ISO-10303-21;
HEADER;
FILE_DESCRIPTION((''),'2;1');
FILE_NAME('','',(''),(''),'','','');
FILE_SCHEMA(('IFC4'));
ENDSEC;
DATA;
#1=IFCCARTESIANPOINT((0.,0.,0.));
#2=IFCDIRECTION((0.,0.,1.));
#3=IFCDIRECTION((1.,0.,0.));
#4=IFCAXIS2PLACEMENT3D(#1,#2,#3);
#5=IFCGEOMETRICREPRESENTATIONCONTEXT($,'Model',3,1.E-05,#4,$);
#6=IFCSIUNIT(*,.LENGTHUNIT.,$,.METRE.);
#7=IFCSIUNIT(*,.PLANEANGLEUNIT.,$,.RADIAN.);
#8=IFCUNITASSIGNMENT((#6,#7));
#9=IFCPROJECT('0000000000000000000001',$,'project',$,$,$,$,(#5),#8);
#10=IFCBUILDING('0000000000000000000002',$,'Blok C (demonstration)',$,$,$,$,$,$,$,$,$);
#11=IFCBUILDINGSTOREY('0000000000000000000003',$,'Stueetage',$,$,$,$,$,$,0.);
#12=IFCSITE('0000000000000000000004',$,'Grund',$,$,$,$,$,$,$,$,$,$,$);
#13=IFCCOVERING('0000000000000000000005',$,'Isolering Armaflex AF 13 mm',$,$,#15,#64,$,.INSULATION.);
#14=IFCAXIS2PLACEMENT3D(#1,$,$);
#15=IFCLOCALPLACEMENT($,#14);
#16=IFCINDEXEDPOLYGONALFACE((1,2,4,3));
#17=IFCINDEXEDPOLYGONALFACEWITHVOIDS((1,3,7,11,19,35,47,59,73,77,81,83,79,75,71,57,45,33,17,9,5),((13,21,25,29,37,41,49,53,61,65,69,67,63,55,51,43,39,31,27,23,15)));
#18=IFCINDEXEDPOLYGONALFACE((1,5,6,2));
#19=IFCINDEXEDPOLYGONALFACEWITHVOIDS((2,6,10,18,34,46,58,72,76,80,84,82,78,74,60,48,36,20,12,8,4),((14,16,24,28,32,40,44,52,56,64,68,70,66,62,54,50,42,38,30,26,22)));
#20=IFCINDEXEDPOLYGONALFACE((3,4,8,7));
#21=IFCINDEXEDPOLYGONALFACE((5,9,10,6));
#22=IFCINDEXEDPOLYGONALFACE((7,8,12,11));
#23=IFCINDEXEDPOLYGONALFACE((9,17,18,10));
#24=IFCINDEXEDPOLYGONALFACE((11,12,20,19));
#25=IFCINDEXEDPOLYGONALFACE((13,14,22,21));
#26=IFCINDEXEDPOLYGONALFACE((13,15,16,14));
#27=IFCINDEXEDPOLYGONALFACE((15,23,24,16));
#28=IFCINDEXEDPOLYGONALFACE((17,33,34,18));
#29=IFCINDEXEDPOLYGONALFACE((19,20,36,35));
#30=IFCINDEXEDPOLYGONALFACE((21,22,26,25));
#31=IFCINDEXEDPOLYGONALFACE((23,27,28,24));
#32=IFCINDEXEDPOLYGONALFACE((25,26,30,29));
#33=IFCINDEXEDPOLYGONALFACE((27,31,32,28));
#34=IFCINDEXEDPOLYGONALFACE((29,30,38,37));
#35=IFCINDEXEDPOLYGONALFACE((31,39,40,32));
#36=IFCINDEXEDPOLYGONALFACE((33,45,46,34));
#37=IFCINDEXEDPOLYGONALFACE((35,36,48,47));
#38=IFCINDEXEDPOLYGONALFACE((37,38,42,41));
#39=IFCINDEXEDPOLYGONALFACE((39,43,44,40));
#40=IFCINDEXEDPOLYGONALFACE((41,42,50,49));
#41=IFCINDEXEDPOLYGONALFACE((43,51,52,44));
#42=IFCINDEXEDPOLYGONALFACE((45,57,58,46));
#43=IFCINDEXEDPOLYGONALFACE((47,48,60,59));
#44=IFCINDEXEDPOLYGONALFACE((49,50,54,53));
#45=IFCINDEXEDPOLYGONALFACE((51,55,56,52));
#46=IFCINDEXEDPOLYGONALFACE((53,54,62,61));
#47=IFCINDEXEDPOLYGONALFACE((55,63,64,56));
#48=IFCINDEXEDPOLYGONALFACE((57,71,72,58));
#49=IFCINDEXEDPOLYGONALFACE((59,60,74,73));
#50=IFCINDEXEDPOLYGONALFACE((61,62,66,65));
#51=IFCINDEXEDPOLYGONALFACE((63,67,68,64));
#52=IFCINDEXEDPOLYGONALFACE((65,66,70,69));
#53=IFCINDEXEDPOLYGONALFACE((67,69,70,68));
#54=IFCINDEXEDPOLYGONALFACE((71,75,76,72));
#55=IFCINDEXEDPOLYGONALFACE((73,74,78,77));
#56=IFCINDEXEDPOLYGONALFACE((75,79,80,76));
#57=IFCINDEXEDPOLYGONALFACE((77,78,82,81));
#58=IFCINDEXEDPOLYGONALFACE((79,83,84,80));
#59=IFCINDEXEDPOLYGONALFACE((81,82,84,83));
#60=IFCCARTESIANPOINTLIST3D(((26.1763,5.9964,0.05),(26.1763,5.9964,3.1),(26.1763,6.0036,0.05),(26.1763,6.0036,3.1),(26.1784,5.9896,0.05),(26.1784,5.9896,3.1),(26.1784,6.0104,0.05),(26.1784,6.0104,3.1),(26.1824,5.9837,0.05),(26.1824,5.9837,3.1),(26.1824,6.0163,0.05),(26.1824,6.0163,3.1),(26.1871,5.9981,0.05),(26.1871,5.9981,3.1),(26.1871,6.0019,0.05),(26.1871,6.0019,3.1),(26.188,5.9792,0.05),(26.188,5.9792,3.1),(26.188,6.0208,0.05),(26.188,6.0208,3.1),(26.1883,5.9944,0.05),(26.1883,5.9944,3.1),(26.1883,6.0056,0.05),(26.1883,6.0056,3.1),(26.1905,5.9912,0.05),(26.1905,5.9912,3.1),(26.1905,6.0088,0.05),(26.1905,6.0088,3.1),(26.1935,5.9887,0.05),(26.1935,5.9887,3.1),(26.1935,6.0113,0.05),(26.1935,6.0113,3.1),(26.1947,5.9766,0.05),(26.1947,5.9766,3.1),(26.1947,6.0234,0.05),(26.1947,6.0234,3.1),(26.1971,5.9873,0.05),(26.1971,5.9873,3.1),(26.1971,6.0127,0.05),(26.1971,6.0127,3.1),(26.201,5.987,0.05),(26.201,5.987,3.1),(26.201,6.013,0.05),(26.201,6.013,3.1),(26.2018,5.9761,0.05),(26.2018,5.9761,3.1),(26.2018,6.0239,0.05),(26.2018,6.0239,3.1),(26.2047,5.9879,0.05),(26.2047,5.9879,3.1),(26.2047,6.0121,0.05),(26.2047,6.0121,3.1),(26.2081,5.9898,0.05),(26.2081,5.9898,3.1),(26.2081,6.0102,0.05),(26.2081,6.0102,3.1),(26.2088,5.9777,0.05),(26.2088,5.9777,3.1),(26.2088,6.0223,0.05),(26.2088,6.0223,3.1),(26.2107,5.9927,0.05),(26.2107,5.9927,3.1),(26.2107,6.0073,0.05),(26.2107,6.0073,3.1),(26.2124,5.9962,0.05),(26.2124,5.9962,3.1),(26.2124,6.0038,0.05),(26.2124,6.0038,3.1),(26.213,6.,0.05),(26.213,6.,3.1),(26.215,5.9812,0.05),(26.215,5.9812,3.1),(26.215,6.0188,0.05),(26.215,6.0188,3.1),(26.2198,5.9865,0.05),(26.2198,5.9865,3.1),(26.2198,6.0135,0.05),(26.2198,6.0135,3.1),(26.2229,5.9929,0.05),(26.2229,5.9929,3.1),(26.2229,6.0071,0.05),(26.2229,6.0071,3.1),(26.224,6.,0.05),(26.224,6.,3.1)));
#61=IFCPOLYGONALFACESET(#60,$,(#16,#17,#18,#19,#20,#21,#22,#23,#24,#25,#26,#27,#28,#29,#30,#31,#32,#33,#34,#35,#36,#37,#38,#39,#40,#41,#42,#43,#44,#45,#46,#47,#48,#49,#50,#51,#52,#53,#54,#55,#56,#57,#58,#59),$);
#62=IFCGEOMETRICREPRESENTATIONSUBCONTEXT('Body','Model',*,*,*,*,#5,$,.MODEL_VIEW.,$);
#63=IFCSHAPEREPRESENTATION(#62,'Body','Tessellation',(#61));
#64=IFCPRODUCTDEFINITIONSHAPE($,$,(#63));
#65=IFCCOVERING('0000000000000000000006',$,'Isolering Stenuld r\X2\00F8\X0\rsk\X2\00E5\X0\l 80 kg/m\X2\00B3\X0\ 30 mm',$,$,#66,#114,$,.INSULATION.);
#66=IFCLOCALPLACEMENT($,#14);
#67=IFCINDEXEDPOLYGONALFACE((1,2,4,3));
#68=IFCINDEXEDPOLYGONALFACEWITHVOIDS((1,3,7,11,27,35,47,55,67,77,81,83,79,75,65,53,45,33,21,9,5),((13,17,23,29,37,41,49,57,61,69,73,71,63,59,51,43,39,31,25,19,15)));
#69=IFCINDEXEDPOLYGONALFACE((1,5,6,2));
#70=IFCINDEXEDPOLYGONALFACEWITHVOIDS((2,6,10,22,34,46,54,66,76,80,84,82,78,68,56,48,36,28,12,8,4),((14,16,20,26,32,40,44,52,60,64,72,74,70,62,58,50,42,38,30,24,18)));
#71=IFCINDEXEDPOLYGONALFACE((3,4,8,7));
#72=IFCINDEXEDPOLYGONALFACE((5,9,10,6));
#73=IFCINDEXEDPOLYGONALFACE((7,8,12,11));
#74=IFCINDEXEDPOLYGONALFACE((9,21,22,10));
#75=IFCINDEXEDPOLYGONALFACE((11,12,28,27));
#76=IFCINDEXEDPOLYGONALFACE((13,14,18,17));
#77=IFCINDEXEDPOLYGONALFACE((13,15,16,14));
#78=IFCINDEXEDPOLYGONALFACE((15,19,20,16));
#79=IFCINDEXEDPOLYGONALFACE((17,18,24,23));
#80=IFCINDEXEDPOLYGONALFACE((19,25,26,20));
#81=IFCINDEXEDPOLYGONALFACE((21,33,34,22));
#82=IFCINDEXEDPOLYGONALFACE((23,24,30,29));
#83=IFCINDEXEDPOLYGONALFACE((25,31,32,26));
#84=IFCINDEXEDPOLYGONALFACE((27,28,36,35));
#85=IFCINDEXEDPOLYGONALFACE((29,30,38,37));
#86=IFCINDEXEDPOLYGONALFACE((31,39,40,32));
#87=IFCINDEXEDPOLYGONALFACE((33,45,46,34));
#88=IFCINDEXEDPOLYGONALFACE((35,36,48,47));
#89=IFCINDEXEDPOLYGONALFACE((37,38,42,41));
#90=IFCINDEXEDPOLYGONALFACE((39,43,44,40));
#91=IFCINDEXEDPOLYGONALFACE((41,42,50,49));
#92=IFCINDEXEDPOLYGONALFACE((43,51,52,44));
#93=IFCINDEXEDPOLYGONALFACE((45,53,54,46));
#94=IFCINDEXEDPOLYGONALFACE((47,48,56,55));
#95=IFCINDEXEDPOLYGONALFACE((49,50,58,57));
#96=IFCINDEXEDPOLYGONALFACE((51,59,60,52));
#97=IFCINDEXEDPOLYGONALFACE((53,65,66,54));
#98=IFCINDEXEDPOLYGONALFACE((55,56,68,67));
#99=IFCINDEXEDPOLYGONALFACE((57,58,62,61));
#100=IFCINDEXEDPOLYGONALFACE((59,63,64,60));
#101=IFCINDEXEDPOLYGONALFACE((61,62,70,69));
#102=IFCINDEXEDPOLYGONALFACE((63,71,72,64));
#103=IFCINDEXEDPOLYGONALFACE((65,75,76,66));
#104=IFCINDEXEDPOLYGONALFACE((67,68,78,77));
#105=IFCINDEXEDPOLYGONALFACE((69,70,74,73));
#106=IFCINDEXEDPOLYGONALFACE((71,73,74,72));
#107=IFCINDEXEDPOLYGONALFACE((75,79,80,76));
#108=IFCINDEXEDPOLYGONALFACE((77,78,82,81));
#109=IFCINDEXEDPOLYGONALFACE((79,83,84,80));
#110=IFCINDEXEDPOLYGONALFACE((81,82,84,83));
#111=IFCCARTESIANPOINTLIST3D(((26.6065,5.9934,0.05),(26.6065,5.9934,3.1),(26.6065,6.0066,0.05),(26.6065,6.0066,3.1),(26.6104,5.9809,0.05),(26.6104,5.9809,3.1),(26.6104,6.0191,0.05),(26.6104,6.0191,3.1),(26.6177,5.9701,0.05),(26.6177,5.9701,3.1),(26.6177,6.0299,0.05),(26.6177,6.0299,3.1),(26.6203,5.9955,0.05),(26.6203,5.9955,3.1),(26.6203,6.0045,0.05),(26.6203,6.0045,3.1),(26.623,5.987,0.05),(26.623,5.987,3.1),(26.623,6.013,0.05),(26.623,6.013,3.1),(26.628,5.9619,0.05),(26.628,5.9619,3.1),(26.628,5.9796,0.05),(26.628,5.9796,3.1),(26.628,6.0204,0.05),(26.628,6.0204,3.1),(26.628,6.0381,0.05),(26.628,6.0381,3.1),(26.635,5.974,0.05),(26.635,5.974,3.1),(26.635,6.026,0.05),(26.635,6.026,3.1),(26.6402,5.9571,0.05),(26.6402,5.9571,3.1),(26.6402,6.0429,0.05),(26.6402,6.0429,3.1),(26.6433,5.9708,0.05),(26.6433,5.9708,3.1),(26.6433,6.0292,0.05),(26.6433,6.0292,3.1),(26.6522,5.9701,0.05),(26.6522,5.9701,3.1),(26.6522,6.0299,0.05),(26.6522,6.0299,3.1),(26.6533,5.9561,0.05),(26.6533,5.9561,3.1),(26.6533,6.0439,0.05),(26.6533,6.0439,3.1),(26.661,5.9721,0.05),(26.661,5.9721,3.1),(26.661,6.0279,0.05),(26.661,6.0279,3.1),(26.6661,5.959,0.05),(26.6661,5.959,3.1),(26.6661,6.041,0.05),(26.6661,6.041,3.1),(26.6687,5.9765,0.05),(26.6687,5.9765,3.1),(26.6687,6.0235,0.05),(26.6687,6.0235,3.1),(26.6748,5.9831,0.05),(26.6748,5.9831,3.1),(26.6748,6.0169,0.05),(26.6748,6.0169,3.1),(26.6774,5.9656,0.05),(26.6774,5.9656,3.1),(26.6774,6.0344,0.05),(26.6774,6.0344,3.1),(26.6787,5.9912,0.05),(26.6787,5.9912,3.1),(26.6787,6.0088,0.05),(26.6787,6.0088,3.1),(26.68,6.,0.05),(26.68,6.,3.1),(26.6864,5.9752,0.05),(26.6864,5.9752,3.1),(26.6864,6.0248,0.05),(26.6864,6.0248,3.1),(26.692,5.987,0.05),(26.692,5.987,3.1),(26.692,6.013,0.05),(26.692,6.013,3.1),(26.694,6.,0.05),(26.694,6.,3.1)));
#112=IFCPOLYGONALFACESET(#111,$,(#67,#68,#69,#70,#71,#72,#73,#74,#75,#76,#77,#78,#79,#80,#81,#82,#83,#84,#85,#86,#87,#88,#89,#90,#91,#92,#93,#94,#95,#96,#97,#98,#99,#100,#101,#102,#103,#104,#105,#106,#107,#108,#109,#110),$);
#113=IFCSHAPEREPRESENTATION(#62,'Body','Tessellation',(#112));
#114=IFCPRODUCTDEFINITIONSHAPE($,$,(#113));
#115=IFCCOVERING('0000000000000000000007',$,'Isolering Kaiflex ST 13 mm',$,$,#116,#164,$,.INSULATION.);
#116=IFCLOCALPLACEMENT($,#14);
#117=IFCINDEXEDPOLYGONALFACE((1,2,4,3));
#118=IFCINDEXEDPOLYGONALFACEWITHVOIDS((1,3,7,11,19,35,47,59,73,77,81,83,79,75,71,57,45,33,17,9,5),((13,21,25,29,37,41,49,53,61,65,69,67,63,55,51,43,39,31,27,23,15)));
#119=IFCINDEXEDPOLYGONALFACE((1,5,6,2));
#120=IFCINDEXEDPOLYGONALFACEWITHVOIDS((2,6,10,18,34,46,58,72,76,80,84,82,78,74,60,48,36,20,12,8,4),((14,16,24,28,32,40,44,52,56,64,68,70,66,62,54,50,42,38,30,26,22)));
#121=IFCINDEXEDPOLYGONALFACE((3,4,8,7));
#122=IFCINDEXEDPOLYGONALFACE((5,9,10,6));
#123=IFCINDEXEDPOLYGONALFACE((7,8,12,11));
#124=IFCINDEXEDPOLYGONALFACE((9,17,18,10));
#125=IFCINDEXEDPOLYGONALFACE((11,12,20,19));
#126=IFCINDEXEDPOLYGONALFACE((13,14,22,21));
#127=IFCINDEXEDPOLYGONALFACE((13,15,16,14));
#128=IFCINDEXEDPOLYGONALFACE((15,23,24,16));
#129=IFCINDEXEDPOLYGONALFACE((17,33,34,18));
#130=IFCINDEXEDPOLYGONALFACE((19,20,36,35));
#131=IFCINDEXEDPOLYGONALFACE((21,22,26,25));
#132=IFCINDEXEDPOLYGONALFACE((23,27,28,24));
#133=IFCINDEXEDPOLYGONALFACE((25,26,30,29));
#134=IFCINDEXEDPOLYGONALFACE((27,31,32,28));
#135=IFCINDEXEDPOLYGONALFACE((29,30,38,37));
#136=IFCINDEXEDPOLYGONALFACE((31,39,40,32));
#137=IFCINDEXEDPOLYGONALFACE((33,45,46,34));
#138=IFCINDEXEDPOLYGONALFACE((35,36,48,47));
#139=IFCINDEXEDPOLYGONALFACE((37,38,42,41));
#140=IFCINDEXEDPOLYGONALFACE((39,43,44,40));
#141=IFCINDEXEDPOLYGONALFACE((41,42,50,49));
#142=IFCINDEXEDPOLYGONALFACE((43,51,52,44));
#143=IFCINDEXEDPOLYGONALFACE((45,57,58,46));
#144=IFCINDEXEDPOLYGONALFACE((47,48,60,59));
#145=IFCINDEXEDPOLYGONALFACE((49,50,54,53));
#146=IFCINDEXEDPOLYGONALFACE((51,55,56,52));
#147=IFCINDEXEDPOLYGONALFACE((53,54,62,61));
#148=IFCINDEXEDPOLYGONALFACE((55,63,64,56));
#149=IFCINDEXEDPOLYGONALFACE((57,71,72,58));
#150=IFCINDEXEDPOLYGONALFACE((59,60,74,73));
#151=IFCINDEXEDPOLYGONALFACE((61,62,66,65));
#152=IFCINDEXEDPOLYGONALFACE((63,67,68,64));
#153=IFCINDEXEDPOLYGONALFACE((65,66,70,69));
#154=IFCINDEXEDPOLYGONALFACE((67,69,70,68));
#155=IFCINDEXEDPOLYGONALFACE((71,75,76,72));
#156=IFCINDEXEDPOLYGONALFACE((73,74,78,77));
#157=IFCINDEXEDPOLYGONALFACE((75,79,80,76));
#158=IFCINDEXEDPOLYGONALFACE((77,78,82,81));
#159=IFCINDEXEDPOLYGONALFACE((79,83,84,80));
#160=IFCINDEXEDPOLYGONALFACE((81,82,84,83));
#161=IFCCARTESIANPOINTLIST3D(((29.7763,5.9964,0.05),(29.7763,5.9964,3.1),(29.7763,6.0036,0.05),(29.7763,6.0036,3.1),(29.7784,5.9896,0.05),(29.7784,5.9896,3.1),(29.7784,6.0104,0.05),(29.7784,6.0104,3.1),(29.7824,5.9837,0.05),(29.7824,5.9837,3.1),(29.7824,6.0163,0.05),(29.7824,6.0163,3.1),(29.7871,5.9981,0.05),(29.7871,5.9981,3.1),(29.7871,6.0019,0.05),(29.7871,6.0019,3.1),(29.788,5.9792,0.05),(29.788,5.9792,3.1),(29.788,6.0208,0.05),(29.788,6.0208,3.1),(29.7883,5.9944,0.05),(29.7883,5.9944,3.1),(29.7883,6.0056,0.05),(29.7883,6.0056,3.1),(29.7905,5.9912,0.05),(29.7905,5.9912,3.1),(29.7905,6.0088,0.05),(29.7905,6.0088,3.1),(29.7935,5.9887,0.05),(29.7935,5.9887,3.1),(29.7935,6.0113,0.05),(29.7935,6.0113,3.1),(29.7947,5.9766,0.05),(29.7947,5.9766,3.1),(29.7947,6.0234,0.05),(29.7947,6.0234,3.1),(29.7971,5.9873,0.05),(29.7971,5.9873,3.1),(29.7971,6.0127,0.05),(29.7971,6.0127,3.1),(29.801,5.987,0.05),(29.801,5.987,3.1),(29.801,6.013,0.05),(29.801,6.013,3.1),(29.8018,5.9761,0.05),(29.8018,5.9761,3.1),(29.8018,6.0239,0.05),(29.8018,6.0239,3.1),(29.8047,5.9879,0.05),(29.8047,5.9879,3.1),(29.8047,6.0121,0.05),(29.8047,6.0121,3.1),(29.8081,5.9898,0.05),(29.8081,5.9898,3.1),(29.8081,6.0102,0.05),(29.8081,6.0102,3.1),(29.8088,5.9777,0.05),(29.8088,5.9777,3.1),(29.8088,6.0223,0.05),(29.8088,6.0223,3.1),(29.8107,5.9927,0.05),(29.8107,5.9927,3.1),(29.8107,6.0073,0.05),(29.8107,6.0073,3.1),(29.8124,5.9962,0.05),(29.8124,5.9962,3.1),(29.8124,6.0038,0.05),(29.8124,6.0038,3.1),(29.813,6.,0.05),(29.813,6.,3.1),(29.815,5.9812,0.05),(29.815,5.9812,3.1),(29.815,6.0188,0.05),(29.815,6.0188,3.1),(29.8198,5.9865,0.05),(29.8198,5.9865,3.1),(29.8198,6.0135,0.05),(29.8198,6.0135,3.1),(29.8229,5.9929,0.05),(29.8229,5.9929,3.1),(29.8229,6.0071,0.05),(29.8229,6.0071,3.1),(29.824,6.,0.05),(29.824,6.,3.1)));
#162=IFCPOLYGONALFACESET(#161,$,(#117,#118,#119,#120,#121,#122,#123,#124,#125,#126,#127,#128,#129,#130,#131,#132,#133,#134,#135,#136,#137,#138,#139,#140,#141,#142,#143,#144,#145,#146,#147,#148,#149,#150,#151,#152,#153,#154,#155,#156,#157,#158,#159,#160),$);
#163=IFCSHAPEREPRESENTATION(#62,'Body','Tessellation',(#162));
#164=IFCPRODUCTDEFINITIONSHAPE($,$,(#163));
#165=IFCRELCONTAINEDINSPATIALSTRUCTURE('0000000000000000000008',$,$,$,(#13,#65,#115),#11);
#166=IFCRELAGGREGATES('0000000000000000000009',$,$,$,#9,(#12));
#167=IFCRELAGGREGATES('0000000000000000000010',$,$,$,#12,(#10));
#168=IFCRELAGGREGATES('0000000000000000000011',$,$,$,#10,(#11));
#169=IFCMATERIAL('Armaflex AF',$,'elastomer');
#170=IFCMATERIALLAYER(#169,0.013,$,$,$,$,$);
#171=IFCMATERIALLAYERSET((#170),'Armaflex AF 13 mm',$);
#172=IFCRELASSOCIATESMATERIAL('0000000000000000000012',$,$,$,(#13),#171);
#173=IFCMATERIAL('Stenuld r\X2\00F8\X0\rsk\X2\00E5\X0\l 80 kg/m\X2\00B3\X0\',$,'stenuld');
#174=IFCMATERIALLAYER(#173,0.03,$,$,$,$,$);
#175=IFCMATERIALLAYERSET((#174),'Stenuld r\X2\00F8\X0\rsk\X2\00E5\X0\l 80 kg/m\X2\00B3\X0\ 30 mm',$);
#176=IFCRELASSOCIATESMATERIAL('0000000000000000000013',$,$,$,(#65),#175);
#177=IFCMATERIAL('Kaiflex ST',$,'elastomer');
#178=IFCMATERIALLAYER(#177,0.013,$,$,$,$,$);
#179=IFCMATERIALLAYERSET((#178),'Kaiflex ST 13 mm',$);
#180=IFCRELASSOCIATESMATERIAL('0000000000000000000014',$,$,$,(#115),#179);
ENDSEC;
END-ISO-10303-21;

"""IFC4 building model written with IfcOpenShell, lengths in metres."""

from ifc_helpers import new_model, si_unit, frame, origin_with_axes, place, context, subcontext, project, spatial, hollow_circle, extrude, material, layer, layer_set, element, save


model = new_model("IFC4")

# Units and contexts
model_context = context("Model", 3, precision=1e-05, world=origin_with_axes())
body_context = subcontext(model_context, "Body", "Model", "MODEL_VIEW")
ifc_project = project(units=[si_unit("LENGTHUNIT", "METRE"), si_unit("PLANEANGLEUNIT", "RADIAN")], contexts=[model_context])

# Site, building, storey
site = spatial("IfcSite", under=ifc_project, Name="Grund")
building = spatial("IfcBuilding", under=site, Name="Blok C (demonstration)")
storey = spatial("IfcBuildingStorey", under=building, Name="Stueetage", Elevation=0.0)

# Coverings
ifc_material_1 = material(Name="Armaflex AF", Category="elastomer")
ifc_layer_1 = layer(ifc_material_1, 0.013)
ifc_layer_set_1 = layer_set([ifc_layer_1], Name="Armaflex AF 13 mm")
covering_1_placement = place(None, origin_with_axes())
element("IfcCovering", 1, at=covering_1_placement, inside=storey, material=ifc_layer_set_1, Name="Isolering Armaflex AF 13 mm", PredefinedType="INSULATION", context=body_context, shape_type="SweptSolid", body=[
    extrude(hollow_circle(Radius=0.024, WallThickness=0.011), frame((26.2, 6.0, 0.05), z_axis=(0.0, 0.0, 1.0), x_axis=(1.0, 0.0, 0.0)), (0.0, 0.0, 1.0), 3.05),
])
ifc_material_2 = material(Name="Stenuld rørskål 80 kg/m³", Category="stenuld")
ifc_layer_2 = layer(ifc_material_2, 0.03)
ifc_layer_set_2 = layer_set([ifc_layer_2], Name="Stenuld rørskål 80 kg/m³ 30 mm")
covering_2_placement = place(None, origin_with_axes())
element("IfcCovering", 2, at=covering_2_placement, inside=storey, material=ifc_layer_set_2, Name="Isolering Stenuld rørskål 80 kg/m³ 30 mm", PredefinedType="INSULATION", context=body_context, shape_type="SweptSolid", body=[
    extrude(hollow_circle(Radius=0.044, WallThickness=0.014), frame((26.65, 6.0, 0.05), z_axis=(0.0, 0.0, 1.0), x_axis=(1.0, 0.0, 0.0)), (0.0, 0.0, 1.0), 3.05),
])
ifc_material_3 = material(Name="Kaiflex ST", Category="elastomer")
ifc_layer_3 = layer(ifc_material_3, 0.013)
ifc_layer_set_3 = layer_set([ifc_layer_3], Name="Kaiflex ST 13 mm")
covering_3_placement = place(None, origin_with_axes())
element("IfcCovering", 3, at=covering_3_placement, inside=storey, material=ifc_layer_set_3, Name="Isolering Kaiflex ST 13 mm", PredefinedType="INSULATION", context=body_context, shape_type="SweptSolid", body=[
    extrude(hollow_circle(Radius=0.024, WallThickness=0.011), frame((29.8, 6.0, 0.05), z_axis=(0.0, 0.0, 1.0), x_axis=(1.0, 0.0, 0.0)), (0.0, 0.0, 1.0), 3.05),
])

save(model, "model.ifc")
